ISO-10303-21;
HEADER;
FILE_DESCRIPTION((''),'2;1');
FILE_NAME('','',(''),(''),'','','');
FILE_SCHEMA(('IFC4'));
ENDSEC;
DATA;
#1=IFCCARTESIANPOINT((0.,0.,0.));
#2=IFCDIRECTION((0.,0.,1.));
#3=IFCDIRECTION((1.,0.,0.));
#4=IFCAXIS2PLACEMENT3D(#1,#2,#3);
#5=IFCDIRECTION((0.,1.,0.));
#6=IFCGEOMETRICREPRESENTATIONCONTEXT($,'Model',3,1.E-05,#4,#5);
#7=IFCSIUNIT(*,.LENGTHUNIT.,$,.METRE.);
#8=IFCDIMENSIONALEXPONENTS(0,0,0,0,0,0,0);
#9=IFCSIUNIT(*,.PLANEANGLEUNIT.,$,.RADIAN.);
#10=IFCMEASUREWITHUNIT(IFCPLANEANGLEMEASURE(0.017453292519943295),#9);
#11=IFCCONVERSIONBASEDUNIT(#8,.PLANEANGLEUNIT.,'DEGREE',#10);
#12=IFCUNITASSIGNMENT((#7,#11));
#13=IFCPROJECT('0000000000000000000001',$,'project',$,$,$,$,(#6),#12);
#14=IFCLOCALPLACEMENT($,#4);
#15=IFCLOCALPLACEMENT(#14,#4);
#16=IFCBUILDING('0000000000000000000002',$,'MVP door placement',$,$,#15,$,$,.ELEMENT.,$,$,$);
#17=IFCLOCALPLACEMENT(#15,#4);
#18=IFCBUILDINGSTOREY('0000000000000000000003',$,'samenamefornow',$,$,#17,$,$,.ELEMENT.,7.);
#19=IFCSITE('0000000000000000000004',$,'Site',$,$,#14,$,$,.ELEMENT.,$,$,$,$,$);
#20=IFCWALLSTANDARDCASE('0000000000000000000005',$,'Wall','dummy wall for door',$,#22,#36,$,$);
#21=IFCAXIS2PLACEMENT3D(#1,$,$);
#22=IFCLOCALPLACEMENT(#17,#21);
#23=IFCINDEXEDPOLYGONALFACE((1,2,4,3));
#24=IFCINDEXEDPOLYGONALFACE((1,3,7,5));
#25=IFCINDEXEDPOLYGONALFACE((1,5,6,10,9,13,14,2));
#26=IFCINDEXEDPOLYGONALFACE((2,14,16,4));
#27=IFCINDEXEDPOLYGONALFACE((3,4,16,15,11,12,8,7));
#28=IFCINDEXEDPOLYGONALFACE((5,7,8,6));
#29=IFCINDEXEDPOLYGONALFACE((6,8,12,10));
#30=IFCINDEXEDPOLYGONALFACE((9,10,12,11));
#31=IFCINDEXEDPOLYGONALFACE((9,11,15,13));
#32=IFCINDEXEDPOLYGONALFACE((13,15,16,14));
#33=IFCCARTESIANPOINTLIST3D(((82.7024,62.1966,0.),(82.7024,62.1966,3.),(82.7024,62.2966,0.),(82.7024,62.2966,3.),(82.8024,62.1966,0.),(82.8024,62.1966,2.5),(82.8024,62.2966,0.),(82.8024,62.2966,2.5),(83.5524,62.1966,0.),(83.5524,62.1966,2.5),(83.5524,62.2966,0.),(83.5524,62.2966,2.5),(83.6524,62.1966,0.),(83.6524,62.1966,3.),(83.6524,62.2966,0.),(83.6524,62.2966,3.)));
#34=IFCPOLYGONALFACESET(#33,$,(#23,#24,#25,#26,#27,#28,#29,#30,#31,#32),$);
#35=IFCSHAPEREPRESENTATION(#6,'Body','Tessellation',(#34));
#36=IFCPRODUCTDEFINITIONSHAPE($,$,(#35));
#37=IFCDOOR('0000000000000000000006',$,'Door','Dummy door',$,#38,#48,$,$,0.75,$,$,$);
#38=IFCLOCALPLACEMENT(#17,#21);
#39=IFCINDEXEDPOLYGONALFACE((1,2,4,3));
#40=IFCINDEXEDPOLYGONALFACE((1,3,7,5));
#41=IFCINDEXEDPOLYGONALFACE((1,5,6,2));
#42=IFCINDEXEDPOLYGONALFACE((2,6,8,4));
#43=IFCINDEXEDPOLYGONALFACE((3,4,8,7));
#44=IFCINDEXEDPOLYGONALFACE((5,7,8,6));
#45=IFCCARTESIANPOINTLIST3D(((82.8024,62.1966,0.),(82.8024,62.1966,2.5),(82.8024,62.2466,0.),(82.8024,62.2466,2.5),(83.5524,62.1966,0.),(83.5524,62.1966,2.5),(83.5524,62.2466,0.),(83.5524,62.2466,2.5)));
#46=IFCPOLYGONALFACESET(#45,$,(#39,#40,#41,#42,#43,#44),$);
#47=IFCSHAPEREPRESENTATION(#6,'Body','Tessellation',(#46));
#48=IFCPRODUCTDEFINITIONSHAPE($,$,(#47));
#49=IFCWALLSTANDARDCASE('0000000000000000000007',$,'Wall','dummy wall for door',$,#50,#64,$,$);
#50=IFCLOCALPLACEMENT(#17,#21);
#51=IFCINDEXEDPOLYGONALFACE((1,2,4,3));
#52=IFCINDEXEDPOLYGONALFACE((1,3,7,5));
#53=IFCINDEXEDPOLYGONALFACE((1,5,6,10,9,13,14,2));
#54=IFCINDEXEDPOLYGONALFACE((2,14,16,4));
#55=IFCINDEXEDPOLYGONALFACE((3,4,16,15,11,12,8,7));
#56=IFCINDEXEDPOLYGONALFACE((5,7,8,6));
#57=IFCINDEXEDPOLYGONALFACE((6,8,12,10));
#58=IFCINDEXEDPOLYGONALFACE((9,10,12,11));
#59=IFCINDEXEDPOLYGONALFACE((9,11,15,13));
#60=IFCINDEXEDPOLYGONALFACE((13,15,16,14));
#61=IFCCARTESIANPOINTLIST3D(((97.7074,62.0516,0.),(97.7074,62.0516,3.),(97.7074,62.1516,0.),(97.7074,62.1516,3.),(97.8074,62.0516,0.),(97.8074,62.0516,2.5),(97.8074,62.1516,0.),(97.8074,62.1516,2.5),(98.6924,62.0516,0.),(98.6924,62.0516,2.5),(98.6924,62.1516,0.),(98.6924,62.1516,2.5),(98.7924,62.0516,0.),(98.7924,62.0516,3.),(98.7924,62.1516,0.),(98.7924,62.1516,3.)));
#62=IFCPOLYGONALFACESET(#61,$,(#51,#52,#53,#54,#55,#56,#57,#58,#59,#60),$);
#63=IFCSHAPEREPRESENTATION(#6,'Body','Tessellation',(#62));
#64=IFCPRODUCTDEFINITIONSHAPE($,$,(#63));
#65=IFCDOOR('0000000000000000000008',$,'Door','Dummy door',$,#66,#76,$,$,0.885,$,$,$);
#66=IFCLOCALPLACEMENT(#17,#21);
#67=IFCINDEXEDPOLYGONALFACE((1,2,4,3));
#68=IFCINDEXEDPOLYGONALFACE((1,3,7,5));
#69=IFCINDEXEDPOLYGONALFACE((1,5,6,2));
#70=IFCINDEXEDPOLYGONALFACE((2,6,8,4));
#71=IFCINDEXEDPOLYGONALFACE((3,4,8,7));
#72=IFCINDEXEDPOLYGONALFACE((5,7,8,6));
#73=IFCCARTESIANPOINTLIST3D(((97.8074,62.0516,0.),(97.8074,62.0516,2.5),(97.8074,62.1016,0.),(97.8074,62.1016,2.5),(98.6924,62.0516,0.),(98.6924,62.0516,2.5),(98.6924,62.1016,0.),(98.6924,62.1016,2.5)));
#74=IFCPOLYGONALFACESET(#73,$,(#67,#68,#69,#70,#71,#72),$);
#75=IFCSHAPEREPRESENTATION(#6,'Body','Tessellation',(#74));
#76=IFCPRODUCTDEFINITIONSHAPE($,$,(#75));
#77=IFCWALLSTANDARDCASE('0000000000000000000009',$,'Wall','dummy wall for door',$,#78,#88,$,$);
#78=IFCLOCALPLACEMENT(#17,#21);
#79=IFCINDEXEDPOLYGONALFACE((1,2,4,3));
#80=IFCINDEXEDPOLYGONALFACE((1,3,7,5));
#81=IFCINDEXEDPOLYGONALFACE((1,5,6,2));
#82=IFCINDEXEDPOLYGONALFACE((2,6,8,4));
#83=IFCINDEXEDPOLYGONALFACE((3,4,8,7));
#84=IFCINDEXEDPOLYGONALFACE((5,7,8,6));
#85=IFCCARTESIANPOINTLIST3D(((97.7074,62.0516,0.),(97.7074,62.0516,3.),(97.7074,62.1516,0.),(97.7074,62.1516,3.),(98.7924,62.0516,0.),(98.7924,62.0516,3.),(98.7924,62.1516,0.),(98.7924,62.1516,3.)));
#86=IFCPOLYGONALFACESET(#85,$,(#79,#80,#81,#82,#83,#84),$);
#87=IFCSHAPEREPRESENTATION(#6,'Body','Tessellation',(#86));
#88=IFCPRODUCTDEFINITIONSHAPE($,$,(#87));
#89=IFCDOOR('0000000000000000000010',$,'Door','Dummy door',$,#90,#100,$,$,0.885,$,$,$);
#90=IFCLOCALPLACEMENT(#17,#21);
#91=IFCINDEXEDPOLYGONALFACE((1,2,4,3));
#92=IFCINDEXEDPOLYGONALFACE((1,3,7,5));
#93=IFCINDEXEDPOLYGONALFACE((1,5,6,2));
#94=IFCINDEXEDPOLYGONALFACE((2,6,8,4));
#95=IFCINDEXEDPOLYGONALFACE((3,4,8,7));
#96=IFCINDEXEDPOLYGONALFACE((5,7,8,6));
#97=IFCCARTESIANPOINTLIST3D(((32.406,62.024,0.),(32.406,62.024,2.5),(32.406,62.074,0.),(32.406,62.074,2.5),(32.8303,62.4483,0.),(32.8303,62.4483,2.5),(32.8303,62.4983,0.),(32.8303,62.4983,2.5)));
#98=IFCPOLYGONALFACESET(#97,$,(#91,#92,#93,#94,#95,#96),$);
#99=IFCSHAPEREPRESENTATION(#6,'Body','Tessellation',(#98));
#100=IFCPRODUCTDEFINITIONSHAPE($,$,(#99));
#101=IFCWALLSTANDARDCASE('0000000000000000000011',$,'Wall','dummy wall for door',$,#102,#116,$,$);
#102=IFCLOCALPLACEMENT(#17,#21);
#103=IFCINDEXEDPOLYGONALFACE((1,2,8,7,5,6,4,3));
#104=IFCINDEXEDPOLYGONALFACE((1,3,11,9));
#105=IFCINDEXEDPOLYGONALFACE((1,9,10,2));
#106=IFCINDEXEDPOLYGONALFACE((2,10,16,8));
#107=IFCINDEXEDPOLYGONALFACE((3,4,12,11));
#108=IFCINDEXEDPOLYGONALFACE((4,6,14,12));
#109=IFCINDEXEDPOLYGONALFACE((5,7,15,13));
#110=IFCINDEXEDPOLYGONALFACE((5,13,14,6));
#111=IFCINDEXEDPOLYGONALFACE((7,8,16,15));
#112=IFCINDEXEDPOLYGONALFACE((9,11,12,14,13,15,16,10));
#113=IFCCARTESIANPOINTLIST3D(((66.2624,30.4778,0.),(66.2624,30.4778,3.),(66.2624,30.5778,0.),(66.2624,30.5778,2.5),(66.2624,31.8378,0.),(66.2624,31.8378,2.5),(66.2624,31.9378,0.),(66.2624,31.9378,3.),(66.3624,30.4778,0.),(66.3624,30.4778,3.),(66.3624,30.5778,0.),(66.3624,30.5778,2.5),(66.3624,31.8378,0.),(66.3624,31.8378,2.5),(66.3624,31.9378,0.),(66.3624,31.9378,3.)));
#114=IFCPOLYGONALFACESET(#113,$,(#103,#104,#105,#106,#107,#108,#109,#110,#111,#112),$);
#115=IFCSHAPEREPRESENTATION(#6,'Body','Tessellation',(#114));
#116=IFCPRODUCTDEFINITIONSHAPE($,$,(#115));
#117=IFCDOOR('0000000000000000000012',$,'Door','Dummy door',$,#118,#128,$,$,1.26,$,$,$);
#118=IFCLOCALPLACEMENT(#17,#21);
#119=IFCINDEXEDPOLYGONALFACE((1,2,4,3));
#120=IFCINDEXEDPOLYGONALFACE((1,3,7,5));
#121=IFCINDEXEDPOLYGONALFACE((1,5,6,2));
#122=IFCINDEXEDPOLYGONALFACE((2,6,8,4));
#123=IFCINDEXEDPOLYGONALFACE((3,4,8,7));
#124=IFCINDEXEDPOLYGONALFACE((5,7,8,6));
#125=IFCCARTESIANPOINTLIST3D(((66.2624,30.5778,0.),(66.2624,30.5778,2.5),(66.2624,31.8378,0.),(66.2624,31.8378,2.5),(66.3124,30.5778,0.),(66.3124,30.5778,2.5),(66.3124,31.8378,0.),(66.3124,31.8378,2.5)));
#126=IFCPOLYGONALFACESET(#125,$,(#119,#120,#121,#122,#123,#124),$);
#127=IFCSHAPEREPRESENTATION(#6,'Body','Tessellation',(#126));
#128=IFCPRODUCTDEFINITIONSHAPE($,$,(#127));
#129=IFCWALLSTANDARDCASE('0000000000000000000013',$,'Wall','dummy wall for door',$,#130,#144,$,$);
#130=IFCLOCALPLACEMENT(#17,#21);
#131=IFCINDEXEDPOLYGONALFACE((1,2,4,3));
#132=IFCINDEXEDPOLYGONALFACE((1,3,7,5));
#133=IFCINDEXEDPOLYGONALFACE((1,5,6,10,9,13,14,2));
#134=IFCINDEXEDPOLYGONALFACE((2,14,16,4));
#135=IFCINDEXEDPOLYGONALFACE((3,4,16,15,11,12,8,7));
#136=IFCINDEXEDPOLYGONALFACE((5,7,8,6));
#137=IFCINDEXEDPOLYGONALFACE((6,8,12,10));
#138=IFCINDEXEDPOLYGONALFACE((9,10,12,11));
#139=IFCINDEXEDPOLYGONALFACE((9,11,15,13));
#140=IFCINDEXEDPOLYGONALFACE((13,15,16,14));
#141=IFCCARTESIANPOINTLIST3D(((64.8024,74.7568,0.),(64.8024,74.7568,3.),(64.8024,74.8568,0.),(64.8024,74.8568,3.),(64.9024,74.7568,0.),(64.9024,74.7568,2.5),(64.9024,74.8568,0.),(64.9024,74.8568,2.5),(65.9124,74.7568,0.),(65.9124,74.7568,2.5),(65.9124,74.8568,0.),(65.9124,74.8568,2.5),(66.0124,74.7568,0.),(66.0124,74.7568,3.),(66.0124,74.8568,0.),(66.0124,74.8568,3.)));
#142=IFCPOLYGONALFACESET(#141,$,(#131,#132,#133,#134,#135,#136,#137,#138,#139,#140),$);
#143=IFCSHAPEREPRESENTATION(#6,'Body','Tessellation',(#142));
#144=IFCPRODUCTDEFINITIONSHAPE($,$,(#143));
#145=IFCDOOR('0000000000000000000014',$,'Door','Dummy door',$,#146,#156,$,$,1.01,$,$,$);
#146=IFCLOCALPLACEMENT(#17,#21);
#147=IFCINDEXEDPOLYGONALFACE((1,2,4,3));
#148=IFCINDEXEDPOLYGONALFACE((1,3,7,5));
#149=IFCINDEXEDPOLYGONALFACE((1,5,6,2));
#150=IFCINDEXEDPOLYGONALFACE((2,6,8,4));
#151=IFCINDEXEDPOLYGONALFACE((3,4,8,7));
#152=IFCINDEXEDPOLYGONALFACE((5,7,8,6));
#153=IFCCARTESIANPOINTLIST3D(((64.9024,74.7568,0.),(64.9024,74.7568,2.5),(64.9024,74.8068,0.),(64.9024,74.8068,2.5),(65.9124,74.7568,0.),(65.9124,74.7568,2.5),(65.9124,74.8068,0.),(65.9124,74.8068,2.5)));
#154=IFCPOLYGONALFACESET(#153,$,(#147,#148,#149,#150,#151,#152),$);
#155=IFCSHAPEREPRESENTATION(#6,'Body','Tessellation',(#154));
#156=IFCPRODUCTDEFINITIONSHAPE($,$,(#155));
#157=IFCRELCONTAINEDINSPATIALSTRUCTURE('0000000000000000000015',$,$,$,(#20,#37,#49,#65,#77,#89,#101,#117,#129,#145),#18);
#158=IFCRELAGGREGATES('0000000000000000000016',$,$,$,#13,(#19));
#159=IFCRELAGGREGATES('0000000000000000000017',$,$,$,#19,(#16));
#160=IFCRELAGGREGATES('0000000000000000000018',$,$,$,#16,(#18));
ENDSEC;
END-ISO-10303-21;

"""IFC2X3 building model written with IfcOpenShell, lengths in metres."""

from ifc_helpers import new_model, entity, si_unit, converted_unit, direction, origin_with_axes, place, context, project, spatial, polyline, outline, extrude, element, fill, save


model = new_model("IFC2X3")

# Units and contexts
model_context = context("Model", 3, precision=1e-05, world=origin_with_axes(), true_north=direction((0.0, 1.0, 0.0)))
ifc_project = project(units=[si_unit("LENGTHUNIT", "METRE"), converted_unit("PLANEANGLEUNIT", "DEGREE", entity("IfcPlaneAngleMeasure", 0.017453292519943295), si_unit("PLANEANGLEUNIT", "RADIAN"), dimensions=[0, 0, 0, 0, 0, 0, 0])], contexts=[model_context])

# Site, building, storey
site_placement = place(None, origin_with_axes())
site = spatial("IfcSite", under=ifc_project, at=site_placement, Name="Site", CompositionType="ELEMENT")
building_placement = place(site_placement, origin_with_axes())
building = spatial("IfcBuilding", under=site, at=building_placement, Name="MVP door placement", CompositionType="ELEMENT")
storey_placement = place(building_placement, origin_with_axes())
storey = spatial("IfcBuildingStorey", under=building, at=storey_placement, Name="samenamefornow", CompositionType="ELEMENT", Elevation=7.0)

# Walls, openings, doors
wall_1_placement = place(storey_placement, origin_with_axes())
wall_1 = element("IfcWallStandardCase", 1, at=wall_1_placement, inside=storey, Name="Wall", Description="dummy wall for door", context=model_context, shape_type="SweptSolid", body=[
    extrude(outline(polyline([(82.7024, 62.1966, 0.0), (83.6524, 62.1966, 0.0), (83.6524, 62.2966, 0.0), (82.7024, 62.2966, 0.0), (82.7024, 62.1966, 0.0)])), origin_with_axes(), (0.0, 0.0, 1.0), 3.0),
])
opening_1_placement = place(wall_1_placement, origin_with_axes())
opening_1 = element("IfcOpeningElement", 2, at=opening_1_placement, cuts=wall_1, context=model_context, shape_type="SweptSolid", body=[
    extrude(outline(polyline([(82.8024, 62.1966, 0.0), (83.5524, 62.1966, 0.0), (83.5524, 62.2966, 0.0), (82.8024, 62.2966, 0.0), (82.8024, 62.1966, 0.0)])), origin_with_axes(), (0.0, 0.0, 1.0), 2.5),
])
door_1_placement = place(opening_1_placement, origin_with_axes())
door_1 = element("IfcDoor", 3, at=door_1_placement, inside=storey, Name="Door", Description="Dummy door", OverallWidth=0.75, context=model_context, shape_type="SweptSolid", body=[
    extrude(outline(polyline([(82.8024, 62.1966, 0.0), (83.5524, 62.1966, 0.0), (83.5524, 62.2466, 0.0), (82.8024, 62.2466, 0.0), (82.8024, 62.1966, 0.0)])), origin_with_axes(), (0.0, 0.0, 1.0), 2.5),
])
fill(opening_1, door_1)
wall_2_placement = place(storey_placement, origin_with_axes())
wall_2 = element("IfcWallStandardCase", 4, at=wall_2_placement, inside=storey, Name="Wall", Description="dummy wall for door", context=model_context, shape_type="SweptSolid", body=[
    extrude(outline(polyline([(97.7074, 62.0516, 0.0), (98.7924, 62.0516, 0.0), (98.7924, 62.1516, 0.0), (97.7074, 62.1516, 0.0), (97.7074, 62.0516, 0.0)])), origin_with_axes(), (0.0, 0.0, 1.0), 3.0),
])
opening_2_placement = place(wall_2_placement, origin_with_axes())
opening_2 = element("IfcOpeningElement", 5, at=opening_2_placement, cuts=wall_2, context=model_context, shape_type="SweptSolid", body=[
    extrude(outline(polyline([(97.8074, 62.0516, 0.0), (98.6924, 62.0516, 0.0), (98.6924, 62.1516, 0.0), (97.8074, 62.1516, 0.0), (97.8074, 62.0516, 0.0)])), origin_with_axes(), (0.0, 0.0, 1.0), 2.5),
])
door_2_placement = place(opening_2_placement, origin_with_axes())
door_2 = element("IfcDoor", 6, at=door_2_placement, inside=storey, Name="Door", Description="Dummy door", OverallWidth=0.885, context=model_context, shape_type="SweptSolid", body=[
    extrude(outline(polyline([(97.8074, 62.0516, 0.0), (98.6924, 62.0516, 0.0), (98.6924, 62.1016, 0.0), (97.8074, 62.1016, 0.0), (97.8074, 62.0516, 0.0)])), origin_with_axes(), (0.0, 0.0, 1.0), 2.5),
])
fill(opening_2, door_2)
wall_3_placement = place(storey_placement, origin_with_axes())
wall_3 = element("IfcWallStandardCase", 7, at=wall_3_placement, inside=storey, Name="Wall", Description="dummy wall for door", context=model_context, shape_type="SweptSolid", body=[
    extrude(outline(polyline([(97.7074, 62.0516, 0.0), (98.7924, 62.0516, 0.0), (98.7924, 62.1516, 0.0), (97.7074, 62.1516, 0.0), (97.7074, 62.0516, 0.0)])), origin_with_axes(), (0.0, 0.0, 1.0), 3.0),
])
opening_3_placement = place(wall_3_placement, origin_with_axes())
opening_3 = element("IfcOpeningElement", 8, at=opening_3_placement, cuts=wall_3, context=model_context, shape_type="SweptSolid", body=[
    extrude(outline(polyline([(32.406, 62.024, 0.0), (32.8303, 62.4483, 0.0), (32.8303, 62.5483, 0.0), (32.406, 62.124, 0.0), (32.406, 62.024, 0.0)])), origin_with_axes(), (0.0, 0.0, 1.0), 2.5),
])
door_3_placement = place(opening_3_placement, origin_with_axes())
door_3 = element("IfcDoor", 9, at=door_3_placement, inside=storey, Name="Door", Description="Dummy door", OverallWidth=0.885, context=model_context, shape_type="SweptSolid", body=[
    extrude(outline(polyline([(32.406, 62.024, 0.0), (32.8303, 62.4483, 0.0), (32.8303, 62.4983, 0.0), (32.406, 62.074, 0.0), (32.406, 62.024, 0.0)])), origin_with_axes(), (0.0, 0.0, 1.0), 2.5),
])
fill(opening_3, door_3)
wall_4_placement = place(storey_placement, origin_with_axes())
wall_4 = element("IfcWallStandardCase", 10, at=wall_4_placement, inside=storey, Name="Wall", Description="dummy wall for door", context=model_context, shape_type="SweptSolid", body=[
    extrude(outline(polyline([(66.2624, 30.4778, 0.0), (66.2624, 31.9378, 0.0), (66.3624, 31.9378, 0.0), (66.3624, 30.4778, 0.0), (66.2624, 30.4778, 0.0)])), origin_with_axes(), (0.0, 0.0, 1.0), 3.0),
])
opening_4_placement = place(wall_4_placement, origin_with_axes())
opening_4 = element("IfcOpeningElement", 11, at=opening_4_placement, cuts=wall_4, context=model_context, shape_type="SweptSolid", body=[
    extrude(outline(polyline([(66.2624, 30.5778, 0.0), (66.2624, 31.8378, 0.0), (66.3624, 31.8378, 0.0), (66.3624, 30.5778, 0.0), (66.2624, 30.5778, 0.0)])), origin_with_axes(), (0.0, 0.0, 1.0), 2.5),
])
door_4_placement = place(opening_4_placement, origin_with_axes())
door_4 = element("IfcDoor", 12, at=door_4_placement, inside=storey, Name="Door", Description="Dummy door", OverallWidth=1.26, context=model_context, shape_type="SweptSolid", body=[
    extrude(outline(polyline([(66.2624, 30.5778, 0.0), (66.2624, 31.8378, 0.0), (66.3124, 31.8378, 0.0), (66.3124, 30.5778, 0.0), (66.2624, 30.5778, 0.0)])), origin_with_axes(), (0.0, 0.0, 1.0), 2.5),
])
fill(opening_4, door_4)
wall_5_placement = place(storey_placement, origin_with_axes())
wall_5 = element("IfcWallStandardCase", 13, at=wall_5_placement, inside=storey, Name="Wall", Description="dummy wall for door", context=model_context, shape_type="SweptSolid", body=[
    extrude(outline(polyline([(66.0124, 74.7568, 0.0), (64.8024, 74.7568, 0.0), (64.8024, 74.8568, 0.0), (66.0124, 74.8568, 0.0), (66.0124, 74.7568, 0.0)])), origin_with_axes(), (0.0, 0.0, 1.0), 3.0),
])
opening_5_placement = place(wall_5_placement, origin_with_axes())
opening_5 = element("IfcOpeningElement", 14, at=opening_5_placement, cuts=wall_5, context=model_context, shape_type="SweptSolid", body=[
    extrude(outline(polyline([(65.9124, 74.7568, 0.0), (64.9024, 74.7568, 0.0), (64.9024, 74.8568, 0.0), (65.9124, 74.8568, 0.0), (65.9124, 74.7568, 0.0)])), origin_with_axes(), (0.0, 0.0, 1.0), 2.5),
])
door_5_placement = place(opening_5_placement, origin_with_axes())
door_5 = element("IfcDoor", 15, at=door_5_placement, inside=storey, Name="Door", Description="Dummy door", OverallWidth=1.01, context=model_context, shape_type="SweptSolid", body=[
    extrude(outline(polyline([(65.9124, 74.7568, 0.0), (64.9024, 74.7568, 0.0), (64.9024, 74.8068, 0.0), (65.9124, 74.8068, 0.0), (65.9124, 74.7568, 0.0)])), origin_with_axes(), (0.0, 0.0, 1.0), 2.5),
])
fill(opening_5, door_5)

save(model, "model.ifc")
